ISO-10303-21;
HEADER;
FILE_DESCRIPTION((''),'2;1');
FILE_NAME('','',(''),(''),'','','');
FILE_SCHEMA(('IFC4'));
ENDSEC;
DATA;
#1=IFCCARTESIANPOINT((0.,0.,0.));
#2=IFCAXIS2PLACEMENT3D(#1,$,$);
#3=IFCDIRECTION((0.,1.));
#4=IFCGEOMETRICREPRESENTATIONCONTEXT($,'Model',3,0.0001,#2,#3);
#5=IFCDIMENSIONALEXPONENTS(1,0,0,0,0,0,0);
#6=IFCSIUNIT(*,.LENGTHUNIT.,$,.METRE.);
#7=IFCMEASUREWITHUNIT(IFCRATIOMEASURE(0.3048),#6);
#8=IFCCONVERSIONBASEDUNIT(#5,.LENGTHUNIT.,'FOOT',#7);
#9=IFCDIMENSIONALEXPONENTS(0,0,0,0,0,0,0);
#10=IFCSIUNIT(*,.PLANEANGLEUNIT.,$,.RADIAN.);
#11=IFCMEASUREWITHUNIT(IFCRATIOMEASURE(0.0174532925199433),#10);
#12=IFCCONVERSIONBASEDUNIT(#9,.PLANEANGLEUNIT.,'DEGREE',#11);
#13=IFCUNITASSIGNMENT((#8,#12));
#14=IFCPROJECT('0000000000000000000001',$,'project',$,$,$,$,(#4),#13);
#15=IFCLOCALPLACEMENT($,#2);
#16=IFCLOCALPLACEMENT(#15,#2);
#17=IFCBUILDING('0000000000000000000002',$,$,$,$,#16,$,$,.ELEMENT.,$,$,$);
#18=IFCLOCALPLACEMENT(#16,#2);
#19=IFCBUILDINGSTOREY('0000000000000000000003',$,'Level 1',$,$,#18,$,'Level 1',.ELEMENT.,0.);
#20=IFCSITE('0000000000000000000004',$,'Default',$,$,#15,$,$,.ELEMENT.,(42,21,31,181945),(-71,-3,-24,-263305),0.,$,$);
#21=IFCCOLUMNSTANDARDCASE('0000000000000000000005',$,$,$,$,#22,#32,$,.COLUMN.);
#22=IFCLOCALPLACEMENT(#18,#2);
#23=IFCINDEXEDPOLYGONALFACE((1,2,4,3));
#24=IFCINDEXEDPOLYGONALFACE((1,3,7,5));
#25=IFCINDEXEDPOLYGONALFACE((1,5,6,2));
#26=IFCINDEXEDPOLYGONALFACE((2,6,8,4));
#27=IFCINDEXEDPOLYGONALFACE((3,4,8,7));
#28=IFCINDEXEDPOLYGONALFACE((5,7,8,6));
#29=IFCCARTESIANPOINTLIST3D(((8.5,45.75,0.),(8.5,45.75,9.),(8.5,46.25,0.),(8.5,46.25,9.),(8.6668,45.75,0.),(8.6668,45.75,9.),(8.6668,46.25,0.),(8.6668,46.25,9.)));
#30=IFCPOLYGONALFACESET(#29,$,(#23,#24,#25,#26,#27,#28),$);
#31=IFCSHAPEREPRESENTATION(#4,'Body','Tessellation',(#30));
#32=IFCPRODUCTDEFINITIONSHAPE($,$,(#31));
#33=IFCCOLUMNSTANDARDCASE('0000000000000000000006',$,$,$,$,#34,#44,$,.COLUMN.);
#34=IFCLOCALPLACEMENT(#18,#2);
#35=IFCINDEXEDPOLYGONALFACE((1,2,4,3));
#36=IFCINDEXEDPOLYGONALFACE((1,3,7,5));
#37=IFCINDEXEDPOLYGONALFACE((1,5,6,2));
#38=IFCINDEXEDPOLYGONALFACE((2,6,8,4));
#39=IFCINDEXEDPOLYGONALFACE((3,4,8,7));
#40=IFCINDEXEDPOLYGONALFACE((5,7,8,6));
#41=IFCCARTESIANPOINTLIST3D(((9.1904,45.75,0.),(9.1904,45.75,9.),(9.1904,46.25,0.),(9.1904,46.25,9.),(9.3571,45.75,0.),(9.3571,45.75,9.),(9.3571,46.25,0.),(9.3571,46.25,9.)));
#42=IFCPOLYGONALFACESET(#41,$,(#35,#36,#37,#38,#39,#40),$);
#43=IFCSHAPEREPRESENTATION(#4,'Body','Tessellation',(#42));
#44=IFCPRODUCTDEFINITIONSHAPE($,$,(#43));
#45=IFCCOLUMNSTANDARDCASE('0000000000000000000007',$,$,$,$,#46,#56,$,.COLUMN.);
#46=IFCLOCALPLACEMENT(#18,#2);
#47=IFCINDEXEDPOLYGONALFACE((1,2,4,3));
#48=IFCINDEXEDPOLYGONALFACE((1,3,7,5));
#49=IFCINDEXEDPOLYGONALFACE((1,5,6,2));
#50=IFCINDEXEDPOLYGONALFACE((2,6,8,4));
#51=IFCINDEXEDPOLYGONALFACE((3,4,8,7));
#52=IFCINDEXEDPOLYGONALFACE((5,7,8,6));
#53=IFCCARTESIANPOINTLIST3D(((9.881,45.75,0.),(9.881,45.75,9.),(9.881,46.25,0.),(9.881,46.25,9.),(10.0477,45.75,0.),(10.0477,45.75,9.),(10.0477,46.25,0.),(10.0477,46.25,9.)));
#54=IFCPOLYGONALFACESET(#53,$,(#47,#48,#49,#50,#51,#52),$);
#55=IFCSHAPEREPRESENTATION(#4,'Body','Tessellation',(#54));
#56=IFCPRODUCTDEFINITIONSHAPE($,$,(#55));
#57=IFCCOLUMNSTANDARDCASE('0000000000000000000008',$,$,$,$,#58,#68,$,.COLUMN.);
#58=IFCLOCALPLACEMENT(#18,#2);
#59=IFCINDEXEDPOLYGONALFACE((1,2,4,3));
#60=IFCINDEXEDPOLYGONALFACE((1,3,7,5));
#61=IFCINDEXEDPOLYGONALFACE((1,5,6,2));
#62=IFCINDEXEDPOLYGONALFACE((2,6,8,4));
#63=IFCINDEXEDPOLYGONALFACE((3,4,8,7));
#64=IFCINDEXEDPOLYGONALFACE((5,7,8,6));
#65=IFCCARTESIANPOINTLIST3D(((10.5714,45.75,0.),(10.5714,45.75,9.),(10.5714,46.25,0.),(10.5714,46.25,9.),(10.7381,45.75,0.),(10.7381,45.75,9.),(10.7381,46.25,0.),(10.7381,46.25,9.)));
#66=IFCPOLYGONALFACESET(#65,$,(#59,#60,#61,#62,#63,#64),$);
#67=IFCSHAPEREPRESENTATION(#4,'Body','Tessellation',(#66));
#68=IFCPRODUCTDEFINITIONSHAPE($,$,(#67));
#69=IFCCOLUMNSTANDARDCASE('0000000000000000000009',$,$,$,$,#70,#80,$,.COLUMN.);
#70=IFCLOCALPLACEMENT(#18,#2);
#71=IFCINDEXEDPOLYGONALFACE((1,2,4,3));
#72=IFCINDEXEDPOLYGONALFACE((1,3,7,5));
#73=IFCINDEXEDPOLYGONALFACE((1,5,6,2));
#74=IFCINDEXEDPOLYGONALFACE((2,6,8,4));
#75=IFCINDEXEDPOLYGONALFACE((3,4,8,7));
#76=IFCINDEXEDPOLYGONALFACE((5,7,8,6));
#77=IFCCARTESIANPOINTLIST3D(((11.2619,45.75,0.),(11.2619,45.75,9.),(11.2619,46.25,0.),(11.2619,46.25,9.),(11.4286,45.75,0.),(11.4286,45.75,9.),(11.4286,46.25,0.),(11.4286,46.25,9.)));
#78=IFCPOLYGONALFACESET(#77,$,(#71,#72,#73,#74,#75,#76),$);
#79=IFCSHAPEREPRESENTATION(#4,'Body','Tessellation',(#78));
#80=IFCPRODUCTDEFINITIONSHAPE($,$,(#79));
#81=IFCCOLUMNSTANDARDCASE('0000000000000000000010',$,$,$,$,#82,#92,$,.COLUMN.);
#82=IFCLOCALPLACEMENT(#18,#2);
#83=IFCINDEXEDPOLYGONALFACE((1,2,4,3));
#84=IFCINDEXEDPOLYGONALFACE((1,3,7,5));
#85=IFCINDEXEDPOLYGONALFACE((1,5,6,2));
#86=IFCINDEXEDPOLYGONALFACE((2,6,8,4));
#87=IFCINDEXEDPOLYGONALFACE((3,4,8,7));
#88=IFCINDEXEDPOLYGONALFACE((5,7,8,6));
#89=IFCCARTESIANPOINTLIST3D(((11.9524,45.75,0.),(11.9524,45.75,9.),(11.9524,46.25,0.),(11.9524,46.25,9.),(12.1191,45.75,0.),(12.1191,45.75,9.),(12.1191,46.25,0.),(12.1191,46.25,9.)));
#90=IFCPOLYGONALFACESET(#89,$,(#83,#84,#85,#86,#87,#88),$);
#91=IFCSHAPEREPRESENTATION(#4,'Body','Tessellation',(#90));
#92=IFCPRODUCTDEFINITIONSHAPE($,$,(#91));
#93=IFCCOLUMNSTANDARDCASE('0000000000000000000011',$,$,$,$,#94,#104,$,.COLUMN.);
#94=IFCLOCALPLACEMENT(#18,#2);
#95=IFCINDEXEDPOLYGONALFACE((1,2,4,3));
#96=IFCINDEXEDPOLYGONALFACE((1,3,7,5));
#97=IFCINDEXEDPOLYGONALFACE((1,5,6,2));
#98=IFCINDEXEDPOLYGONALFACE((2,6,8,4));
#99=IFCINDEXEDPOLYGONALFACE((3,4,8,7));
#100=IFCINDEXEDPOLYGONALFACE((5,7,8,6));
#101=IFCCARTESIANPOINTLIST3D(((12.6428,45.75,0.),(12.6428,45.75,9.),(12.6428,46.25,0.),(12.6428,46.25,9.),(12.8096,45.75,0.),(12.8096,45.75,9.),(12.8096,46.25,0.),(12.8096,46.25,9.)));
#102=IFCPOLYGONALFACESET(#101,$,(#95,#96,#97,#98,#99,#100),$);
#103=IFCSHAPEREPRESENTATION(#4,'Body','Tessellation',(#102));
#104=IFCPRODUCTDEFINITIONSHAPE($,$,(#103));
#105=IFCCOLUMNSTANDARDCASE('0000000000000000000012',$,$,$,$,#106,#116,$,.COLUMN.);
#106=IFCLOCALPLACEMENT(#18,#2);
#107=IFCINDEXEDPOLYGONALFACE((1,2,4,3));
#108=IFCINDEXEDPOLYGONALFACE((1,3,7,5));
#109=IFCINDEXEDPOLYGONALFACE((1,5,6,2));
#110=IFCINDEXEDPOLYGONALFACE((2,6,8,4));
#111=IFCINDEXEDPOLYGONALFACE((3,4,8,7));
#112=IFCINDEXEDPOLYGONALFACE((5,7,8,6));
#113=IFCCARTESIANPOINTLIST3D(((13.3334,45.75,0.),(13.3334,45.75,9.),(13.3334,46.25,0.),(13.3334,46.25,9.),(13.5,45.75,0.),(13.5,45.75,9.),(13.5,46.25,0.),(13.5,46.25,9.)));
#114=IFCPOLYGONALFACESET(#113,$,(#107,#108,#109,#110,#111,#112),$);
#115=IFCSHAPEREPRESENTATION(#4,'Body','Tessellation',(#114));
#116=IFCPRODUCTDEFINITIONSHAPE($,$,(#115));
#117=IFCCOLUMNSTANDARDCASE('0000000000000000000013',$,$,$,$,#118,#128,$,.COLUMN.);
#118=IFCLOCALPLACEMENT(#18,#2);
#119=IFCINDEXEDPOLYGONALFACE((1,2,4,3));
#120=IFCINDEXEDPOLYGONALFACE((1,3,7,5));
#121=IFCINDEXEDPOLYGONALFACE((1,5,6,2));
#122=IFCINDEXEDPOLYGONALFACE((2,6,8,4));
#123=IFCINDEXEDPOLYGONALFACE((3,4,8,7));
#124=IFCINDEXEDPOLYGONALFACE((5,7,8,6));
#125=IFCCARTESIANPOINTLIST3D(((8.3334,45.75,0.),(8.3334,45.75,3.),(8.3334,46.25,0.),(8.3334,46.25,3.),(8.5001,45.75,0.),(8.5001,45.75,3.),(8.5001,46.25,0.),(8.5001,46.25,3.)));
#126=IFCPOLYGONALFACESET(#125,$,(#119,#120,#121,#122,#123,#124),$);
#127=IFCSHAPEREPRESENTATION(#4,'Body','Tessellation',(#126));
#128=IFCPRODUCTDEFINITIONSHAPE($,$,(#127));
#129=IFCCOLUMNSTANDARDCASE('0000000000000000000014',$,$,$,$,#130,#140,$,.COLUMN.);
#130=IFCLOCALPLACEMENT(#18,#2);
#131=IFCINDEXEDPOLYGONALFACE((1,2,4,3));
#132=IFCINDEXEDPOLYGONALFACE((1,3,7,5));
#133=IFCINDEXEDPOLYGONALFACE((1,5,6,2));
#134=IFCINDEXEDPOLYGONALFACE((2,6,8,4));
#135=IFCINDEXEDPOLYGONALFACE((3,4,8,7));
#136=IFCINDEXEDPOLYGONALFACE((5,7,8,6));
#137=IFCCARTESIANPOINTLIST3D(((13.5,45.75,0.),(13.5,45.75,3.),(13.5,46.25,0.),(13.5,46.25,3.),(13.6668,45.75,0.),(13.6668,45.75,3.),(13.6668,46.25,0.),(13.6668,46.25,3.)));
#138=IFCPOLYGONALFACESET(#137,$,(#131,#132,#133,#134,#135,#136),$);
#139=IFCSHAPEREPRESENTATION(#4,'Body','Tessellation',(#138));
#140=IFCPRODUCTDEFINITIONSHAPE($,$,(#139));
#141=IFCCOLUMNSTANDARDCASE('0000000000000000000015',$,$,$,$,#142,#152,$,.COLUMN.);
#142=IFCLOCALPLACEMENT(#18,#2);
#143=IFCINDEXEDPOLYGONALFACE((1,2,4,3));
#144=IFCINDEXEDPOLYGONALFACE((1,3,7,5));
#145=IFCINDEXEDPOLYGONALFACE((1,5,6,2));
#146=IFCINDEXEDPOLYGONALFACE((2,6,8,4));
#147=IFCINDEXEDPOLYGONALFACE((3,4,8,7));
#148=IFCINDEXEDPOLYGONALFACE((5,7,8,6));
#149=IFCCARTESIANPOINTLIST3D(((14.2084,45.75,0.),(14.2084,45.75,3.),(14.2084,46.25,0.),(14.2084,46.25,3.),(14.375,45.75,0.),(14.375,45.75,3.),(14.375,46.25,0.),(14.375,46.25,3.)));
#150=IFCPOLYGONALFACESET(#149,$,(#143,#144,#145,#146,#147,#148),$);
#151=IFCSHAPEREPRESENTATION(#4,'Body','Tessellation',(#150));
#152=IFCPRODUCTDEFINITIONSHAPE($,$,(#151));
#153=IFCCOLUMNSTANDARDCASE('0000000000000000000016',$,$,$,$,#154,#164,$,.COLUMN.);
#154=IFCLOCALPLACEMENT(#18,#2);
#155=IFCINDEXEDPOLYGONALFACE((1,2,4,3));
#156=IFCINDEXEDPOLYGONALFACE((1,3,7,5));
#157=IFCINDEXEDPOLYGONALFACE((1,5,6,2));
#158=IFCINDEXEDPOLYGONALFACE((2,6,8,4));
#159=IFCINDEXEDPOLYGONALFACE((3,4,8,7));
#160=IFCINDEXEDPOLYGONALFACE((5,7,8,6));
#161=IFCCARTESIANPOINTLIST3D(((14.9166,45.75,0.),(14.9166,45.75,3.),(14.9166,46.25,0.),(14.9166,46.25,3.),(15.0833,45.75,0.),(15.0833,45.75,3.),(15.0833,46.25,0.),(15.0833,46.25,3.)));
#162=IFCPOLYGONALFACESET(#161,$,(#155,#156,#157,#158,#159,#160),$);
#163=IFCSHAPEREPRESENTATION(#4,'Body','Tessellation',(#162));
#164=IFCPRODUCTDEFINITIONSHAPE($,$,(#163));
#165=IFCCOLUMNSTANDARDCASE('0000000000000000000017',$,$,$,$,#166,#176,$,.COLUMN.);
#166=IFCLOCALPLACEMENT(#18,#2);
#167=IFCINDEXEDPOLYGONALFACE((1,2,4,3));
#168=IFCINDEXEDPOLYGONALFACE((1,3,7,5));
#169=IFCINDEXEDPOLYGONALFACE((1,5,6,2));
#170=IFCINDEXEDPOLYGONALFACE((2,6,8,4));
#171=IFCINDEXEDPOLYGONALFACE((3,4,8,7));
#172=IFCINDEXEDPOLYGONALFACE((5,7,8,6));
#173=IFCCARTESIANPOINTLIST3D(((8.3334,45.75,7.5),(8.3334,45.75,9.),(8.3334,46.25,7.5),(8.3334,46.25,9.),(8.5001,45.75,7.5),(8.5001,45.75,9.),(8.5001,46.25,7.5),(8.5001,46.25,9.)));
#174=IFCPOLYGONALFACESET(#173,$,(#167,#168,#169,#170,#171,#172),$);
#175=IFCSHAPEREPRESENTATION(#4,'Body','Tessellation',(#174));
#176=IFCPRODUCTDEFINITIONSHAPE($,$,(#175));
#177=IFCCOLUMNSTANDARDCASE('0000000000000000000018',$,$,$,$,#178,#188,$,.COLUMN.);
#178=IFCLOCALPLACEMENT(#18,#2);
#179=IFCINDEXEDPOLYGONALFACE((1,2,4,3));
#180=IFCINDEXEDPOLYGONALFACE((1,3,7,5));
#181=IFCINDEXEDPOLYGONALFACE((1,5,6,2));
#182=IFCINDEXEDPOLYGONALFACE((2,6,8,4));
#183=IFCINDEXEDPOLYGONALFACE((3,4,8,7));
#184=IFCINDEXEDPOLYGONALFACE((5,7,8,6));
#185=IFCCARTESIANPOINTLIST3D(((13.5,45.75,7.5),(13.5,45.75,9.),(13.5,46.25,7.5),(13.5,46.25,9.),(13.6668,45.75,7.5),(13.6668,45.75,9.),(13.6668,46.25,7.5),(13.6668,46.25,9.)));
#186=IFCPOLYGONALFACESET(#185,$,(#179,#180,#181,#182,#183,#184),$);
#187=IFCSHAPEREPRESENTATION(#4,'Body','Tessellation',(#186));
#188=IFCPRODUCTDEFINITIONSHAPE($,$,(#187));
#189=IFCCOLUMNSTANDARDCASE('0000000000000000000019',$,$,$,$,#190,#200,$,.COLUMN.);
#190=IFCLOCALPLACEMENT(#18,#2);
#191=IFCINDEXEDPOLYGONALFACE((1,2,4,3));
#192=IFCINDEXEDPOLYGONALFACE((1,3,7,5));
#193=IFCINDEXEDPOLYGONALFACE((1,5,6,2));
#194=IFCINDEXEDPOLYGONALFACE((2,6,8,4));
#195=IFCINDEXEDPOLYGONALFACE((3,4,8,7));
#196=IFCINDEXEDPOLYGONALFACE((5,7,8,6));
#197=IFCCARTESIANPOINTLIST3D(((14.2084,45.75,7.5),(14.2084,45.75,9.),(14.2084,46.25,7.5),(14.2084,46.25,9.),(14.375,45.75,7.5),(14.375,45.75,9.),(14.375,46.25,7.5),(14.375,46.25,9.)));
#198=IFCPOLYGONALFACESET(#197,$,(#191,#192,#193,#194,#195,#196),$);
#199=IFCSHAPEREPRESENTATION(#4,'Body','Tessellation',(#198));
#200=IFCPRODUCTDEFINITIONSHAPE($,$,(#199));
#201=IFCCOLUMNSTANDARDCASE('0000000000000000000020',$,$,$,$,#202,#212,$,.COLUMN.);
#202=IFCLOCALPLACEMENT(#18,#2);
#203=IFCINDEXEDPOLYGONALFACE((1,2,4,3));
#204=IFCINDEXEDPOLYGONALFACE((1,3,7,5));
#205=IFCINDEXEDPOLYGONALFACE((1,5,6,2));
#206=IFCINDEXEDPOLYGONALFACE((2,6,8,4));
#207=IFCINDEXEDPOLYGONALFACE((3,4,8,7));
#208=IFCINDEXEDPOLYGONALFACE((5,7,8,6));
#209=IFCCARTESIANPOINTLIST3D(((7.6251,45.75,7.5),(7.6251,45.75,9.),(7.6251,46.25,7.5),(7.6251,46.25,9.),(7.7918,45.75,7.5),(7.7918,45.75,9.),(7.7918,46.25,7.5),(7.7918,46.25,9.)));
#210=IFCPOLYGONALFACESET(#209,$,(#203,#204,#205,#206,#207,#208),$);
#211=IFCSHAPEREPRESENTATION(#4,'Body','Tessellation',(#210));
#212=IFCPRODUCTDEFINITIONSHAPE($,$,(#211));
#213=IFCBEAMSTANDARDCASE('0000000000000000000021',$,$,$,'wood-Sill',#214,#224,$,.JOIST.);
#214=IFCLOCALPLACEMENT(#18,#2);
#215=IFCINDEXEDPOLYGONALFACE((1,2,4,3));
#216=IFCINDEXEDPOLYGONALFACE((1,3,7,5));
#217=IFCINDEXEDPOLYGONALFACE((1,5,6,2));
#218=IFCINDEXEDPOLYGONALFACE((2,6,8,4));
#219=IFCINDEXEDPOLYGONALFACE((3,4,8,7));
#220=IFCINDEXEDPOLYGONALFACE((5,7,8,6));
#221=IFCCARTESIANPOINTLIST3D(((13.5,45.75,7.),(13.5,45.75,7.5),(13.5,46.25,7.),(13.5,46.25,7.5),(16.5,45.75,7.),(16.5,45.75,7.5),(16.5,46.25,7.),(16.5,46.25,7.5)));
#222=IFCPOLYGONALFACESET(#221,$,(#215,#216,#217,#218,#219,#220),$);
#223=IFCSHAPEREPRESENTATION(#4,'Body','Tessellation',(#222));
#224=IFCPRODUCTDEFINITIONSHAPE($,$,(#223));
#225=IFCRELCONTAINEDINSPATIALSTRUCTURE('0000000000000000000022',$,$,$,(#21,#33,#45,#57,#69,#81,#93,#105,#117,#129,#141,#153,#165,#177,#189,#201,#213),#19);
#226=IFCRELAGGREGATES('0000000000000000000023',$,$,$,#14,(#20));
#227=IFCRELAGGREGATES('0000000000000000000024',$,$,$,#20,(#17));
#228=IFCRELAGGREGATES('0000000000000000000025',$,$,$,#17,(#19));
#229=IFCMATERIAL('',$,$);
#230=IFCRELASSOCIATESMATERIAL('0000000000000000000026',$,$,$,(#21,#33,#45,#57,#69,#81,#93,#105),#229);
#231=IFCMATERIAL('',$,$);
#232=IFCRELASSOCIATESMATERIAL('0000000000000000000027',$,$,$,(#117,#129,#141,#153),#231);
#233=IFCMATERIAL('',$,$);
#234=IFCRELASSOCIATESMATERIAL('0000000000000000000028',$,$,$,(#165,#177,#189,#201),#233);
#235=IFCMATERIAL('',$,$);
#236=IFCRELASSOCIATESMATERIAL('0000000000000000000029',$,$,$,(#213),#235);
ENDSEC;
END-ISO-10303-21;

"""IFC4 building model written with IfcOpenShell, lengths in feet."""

from ifc_helpers import new_model, entity, si_unit, converted_unit, direction, frame, origin, place, context, project, spatial, rectangle, extrude, material, element, save


model = new_model("IFC4")

# Units and contexts
model_context = context("Model", 3, precision=0.0001, world=origin(), true_north=direction((0.0, 1.0)))
ifc_project = project(units=[converted_unit("LENGTHUNIT", "FOOT", entity("IfcRatioMeasure", 0.3048), si_unit("LENGTHUNIT", "METRE"), dimensions=[1, 0, 0, 0, 0, 0, 0]), converted_unit("PLANEANGLEUNIT", "DEGREE", entity("IfcRatioMeasure", 0.0174532925199433), si_unit("PLANEANGLEUNIT", "RADIAN"), dimensions=[0, 0, 0, 0, 0, 0, 0])], contexts=[model_context])

# Site, building, storey
site_placement = place(None, origin())
site = spatial("IfcSite", under=ifc_project, at=site_placement, Name="Default", CompositionType="ELEMENT", RefLatitude=(42, 21, 31, 181945), RefLongitude=(-71, -3, -24, -263305), RefElevation=0.0)
building_placement = place(site_placement, origin())
building = spatial("IfcBuilding", under=site, at=building_placement, CompositionType="ELEMENT")
storey_placement = place(building_placement, origin())
storey = spatial("IfcBuildingStorey", under=building, at=storey_placement, Name="Level 1", LongName="Level 1", CompositionType="ELEMENT", Elevation=0.0)

# Columns
ifc_material_1 = material(Name="")
placement_1 = place(storey_placement, frame((-0.25, 46.0, 0.0)))
for number, where, z_axis, x_axis in (
    (1, (8.8334, 0.0, 0.0), (0.0, 0.0, 1.0), (1.0, 0.0, 0.0)),
    (2, (9.5238, 0.0, 0.0), (0.0, 0.0, 1.0), (1.0, 0.0, 0.0)),
    (3, (10.2143, 0.0, 0.0), (0.0, 0.0, 1.0), (1.0, 0.0, 0.0)),
    (4, (10.9048, 0.0, 0.0), (0.0, 0.0, 1.0), (1.0, 0.0, 0.0)),
    (5, (11.5953, 0.0, 0.0), (0.0, 0.0, 1.0), (1.0, 0.0, 0.0)),
    (6, (12.2857, 0.0, 0.0), (0.0, 0.0, 1.0), (1.0, 0.0, 0.0)),
    (7, (12.9762, 0.0, 0.0), (0.0, 0.0, 1.0), (1.0, 0.0, 0.0)),
    (8, (13.6667, 0.0, 0.0), (0.0, 0.0, 1.0), (1.0, 0.0, 0.0)),
):
    element("IfcColumnStandardCase", number, at=place(placement_1, frame(where, z_axis=z_axis, x_axis=x_axis)), inside=storey, material=ifc_material_1, PredefinedType="COLUMN", context=model_context, shape_type="SweptSolid", body=[
        extrude(rectangle(XDim=0.1667, YDim=0.5), origin(), (0.0, 0.0, 1.0), 9.0),
    ])
ifc_material_2 = material(Name="")
for number, where, z_axis, x_axis in (
    (9, (8.6667, 0.0, 0.0), (0.0, 0.0, 1.0), (1.0, 0.0, 0.0)),
    (10, (13.8334, 0.0, 0.0), (0.0, 0.0, 1.0), (1.0, 0.0, 0.0)),
    (11, (14.5417, 0.0, 0.0), (0.0, 0.0, 1.0), (1.0, 0.0, 0.0)),
    (12, (15.25, 0.0, 0.0), (0.0, 0.0, 1.0), (1.0, 0.0, 0.0)),
):
    element("IfcColumnStandardCase", number, at=place(placement_1, frame(where, z_axis=z_axis, x_axis=x_axis)), inside=storey, material=ifc_material_2, PredefinedType="COLUMN", context=model_context, shape_type="SweptSolid", body=[
        extrude(rectangle(XDim=0.1667, YDim=0.5), origin(), (0.0, 0.0, 1.0), 3.0),
    ])
ifc_material_3 = material(Name="")
for number, where, z_axis, x_axis in (
    (13, (8.6667, 0.0, 7.5), (0.0, 0.0, 1.0), (1.0, 0.0, 0.0)),
    (14, (13.8334, 0.0, 7.5), (0.0, 0.0, 1.0), (1.0, 0.0, 0.0)),
    (15, (14.5417, 0.0, 7.5), (0.0, 0.0, 1.0), (1.0, 0.0, 0.0)),
    (16, (7.9584, 0.0, 7.5), (0.0, 0.0, 1.0), (1.0, 0.0, 0.0)),
):
    element("IfcColumnStandardCase", number, at=place(placement_1, frame(where, z_axis=z_axis, x_axis=x_axis)), inside=storey, material=ifc_material_3, PredefinedType="COLUMN", context=model_context, shape_type="SweptSolid", body=[
        extrude(rectangle(XDim=0.1667, YDim=0.5), origin(), (0.0, 0.0, 1.0), 1.5),
    ])

# Beam
ifc_material_4 = material(Name="")
for number, where, z_axis, x_axis in (
    (17, (15.25, 0.0, 7.0), (0.0, 0.0, 1.0), (-1.0, 0.0, 0.0)),
):
    element("IfcBeamStandardCase", number, at=place(placement_1, frame(where, z_axis=z_axis, x_axis=x_axis)), inside=storey, material=ifc_material_4, ObjectType="wood-Sill", PredefinedType="JOIST", context=model_context, shape_type="SweptSolid", body=[
        extrude(rectangle(XDim=3.0, YDim=0.5), origin(), (0.0, 0.0, 1.0), 0.5),
    ])

save(model, "model.ifc")
